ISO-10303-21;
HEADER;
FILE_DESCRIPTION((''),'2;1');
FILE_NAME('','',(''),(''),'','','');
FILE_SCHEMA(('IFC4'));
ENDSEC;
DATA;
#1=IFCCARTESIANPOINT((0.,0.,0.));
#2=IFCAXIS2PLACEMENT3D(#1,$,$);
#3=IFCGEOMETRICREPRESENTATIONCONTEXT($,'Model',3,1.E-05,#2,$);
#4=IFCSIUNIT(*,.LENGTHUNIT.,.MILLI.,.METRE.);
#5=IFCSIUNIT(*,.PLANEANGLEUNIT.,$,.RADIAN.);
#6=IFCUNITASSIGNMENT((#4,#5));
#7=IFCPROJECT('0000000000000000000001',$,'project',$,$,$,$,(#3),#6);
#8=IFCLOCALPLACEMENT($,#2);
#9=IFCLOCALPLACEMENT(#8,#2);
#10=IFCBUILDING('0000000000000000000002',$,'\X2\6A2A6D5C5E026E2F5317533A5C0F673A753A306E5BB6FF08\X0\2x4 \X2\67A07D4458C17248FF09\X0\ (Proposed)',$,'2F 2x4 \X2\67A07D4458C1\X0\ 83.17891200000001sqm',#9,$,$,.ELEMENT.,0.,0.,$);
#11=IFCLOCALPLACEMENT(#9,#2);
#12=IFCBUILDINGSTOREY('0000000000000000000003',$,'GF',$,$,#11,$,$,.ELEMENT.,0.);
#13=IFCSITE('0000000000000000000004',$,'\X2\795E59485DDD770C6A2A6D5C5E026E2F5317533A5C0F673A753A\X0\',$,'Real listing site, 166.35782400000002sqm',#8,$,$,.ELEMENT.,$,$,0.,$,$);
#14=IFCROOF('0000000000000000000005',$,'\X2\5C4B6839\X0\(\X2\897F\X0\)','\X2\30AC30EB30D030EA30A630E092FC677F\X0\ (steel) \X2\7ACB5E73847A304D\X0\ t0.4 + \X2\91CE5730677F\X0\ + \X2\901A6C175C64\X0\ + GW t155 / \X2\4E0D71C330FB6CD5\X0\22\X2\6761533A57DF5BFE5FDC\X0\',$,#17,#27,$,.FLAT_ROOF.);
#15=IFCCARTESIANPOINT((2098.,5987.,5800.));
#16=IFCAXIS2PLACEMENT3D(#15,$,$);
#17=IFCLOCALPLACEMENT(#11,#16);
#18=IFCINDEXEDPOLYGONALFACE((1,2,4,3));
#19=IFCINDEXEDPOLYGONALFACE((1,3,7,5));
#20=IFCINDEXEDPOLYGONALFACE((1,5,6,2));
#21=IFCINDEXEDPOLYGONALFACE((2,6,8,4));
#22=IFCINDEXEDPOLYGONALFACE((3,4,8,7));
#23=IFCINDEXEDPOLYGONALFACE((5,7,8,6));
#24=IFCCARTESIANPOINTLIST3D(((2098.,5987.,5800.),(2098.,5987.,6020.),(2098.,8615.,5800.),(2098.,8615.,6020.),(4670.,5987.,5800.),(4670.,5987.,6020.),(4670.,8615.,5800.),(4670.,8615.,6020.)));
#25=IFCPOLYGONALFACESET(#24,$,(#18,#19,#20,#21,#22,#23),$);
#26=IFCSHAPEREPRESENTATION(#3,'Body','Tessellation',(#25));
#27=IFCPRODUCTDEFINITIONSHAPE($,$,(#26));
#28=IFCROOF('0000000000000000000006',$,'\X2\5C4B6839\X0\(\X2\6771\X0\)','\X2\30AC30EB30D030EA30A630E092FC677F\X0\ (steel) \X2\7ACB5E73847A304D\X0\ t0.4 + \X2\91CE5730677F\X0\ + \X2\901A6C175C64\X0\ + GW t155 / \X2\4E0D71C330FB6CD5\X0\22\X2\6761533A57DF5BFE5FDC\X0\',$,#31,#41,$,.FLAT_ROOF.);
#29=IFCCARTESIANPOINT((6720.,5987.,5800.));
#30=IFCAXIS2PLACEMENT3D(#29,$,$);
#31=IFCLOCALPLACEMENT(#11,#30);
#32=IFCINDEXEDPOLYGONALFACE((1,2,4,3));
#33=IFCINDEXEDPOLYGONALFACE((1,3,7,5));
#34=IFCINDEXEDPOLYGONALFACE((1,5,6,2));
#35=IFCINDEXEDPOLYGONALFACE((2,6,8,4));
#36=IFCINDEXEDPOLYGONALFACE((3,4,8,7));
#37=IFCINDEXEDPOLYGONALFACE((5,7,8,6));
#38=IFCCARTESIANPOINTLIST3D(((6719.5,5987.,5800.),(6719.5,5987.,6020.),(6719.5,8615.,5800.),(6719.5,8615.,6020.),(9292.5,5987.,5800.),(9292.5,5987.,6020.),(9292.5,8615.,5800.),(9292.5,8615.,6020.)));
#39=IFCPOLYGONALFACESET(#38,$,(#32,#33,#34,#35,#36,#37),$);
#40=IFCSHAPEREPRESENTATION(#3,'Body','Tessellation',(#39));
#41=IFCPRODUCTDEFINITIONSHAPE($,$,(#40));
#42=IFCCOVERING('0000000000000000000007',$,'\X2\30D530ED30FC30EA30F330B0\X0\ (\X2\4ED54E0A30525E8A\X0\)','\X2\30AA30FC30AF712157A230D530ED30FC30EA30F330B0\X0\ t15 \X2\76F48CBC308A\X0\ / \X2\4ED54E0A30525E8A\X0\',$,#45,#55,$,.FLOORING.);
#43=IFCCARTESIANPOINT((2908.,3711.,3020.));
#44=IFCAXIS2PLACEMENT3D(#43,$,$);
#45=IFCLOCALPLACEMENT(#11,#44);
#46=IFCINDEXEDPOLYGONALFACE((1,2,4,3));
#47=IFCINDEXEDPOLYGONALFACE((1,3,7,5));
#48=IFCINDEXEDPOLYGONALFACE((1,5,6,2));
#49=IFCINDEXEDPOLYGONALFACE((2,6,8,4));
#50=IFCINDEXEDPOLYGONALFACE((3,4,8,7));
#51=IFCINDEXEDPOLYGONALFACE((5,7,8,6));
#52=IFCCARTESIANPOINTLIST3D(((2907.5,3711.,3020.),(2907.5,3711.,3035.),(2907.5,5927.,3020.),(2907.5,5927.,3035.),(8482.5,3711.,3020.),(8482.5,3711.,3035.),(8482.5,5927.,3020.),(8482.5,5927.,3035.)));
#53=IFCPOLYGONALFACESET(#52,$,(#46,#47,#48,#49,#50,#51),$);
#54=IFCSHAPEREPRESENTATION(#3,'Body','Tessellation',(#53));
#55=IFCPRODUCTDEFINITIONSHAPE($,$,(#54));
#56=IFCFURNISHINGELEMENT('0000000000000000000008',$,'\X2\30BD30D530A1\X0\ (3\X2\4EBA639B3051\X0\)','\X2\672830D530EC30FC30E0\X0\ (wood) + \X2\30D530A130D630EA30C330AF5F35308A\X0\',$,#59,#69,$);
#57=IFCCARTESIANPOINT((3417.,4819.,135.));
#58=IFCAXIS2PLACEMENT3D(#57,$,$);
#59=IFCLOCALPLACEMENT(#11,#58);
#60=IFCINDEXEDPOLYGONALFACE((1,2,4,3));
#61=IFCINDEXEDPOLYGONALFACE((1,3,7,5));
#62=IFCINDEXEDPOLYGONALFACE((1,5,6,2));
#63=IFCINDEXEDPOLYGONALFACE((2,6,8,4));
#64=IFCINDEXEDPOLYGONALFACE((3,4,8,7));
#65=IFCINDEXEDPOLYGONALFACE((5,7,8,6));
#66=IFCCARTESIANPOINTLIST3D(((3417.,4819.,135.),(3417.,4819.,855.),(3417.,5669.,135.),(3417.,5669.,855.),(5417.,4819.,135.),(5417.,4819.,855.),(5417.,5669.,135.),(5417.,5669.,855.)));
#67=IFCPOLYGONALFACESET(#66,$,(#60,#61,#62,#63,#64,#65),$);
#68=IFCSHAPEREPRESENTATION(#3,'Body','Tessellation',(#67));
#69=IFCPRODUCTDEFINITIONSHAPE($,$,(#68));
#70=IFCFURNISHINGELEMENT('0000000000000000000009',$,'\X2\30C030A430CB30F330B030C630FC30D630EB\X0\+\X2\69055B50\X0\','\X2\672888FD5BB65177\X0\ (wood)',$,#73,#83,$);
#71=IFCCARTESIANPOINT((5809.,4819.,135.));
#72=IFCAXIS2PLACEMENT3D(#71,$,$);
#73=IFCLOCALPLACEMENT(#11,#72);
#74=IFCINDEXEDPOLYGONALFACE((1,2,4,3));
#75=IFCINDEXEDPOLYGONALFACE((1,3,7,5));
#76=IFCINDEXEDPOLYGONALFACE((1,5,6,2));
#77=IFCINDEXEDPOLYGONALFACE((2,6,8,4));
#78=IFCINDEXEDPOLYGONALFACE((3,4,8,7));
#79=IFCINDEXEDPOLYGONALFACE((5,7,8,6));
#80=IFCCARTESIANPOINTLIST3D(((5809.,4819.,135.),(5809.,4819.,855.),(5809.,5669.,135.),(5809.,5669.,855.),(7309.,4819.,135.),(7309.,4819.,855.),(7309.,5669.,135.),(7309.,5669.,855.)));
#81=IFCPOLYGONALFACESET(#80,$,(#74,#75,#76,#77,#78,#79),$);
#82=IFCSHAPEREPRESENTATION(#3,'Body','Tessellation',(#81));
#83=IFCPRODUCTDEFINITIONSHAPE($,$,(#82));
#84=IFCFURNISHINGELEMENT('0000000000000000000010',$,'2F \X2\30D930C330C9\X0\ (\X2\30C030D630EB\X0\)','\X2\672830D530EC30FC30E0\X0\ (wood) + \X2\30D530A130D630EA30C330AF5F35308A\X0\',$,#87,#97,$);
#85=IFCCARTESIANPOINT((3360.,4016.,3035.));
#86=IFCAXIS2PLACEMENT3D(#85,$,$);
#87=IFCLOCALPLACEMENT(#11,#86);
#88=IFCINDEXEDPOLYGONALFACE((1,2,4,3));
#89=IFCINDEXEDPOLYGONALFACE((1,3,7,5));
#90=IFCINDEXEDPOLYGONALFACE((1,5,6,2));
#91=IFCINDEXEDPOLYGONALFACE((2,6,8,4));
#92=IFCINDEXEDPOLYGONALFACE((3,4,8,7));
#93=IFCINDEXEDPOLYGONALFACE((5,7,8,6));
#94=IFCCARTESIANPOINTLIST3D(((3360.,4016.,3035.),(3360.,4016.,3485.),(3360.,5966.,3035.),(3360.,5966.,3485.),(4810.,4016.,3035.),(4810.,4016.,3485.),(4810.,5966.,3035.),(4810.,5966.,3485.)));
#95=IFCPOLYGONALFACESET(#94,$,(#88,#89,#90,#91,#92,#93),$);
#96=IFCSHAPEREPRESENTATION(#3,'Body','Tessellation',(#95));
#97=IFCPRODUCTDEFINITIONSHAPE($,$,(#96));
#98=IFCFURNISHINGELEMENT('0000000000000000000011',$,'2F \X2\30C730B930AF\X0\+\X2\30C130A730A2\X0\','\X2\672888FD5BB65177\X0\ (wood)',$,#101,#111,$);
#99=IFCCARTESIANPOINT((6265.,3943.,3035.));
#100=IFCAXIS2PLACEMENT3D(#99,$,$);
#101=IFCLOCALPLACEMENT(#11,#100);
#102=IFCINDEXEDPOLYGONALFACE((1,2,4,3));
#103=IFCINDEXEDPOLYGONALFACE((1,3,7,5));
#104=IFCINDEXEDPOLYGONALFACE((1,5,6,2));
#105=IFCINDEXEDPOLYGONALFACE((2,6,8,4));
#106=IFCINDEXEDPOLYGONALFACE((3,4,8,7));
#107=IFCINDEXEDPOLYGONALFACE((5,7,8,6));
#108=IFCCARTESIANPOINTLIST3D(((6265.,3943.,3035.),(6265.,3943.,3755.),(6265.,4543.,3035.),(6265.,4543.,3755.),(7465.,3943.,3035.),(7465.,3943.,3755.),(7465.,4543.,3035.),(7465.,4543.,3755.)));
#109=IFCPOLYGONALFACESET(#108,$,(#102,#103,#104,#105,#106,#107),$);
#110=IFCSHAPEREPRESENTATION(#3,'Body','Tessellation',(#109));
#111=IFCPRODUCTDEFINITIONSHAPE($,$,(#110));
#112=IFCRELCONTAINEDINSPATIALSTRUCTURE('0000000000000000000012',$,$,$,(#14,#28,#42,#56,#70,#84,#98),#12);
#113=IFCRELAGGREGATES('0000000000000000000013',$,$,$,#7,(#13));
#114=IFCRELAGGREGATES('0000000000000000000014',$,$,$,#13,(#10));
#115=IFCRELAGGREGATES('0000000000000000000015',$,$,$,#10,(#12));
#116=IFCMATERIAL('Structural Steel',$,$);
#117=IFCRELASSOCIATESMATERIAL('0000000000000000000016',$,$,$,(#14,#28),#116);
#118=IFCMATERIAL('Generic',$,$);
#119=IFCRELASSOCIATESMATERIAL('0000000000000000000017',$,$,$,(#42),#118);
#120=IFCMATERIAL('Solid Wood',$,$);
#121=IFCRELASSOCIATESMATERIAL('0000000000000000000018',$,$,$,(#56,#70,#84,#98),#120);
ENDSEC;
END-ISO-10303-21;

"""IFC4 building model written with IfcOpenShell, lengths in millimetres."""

from ifc_helpers import new_model, si_unit, frame, frame_2d, origin, place, context, project, spatial, rectangle, extrude, material, element, save


model = new_model("IFC4")

# Units and contexts
model_context = context("Model", 3, precision=1e-05, world=origin())
ifc_project = project(units=[si_unit("LENGTHUNIT", "METRE", prefix="MILLI"), si_unit("PLANEANGLEUNIT", "RADIAN")], contexts=[model_context])

# Site, building, storey
site_placement = place(None, origin())
site = spatial("IfcSite", under=ifc_project, at=site_placement, Name="神奈川県横浜市港北区小机町", ObjectType="Real listing site, 166.35782400000002sqm", CompositionType="ELEMENT", RefElevation=0.0)
building_placement = place(site_placement, origin())
building = spatial("IfcBuilding", under=site, at=building_placement, Name="横浜市港北区小机町の家（2x4 枠組壁版） (Proposed)", ObjectType="2F 2x4 枠組壁 83.17891200000001sqm", CompositionType="ELEMENT", ElevationOfRefHeight=0.0, ElevationOfTerrain=0.0)
storey_placement = place(building_placement, origin())
storey = spatial("IfcBuildingStorey", under=building, at=storey_placement, Name="GF", CompositionType="ELEMENT", Elevation=0.0)

# Shared definitions
ifc_material_1 = material(Name="Solid Wood")

# Roofs
ifc_material_2 = material(Name="Structural Steel")
roof_1_placement = place(storey_placement, frame((2098.0, 5987.0, 5800.0)))
element("IfcRoof", 1, at=roof_1_placement, inside=storey, material=ifc_material_2, Name="屋根(西)", Description="ガルバリウム鋼板 (steel) 立平葺き t0.4 + 野地板 + 通気層 + GW t155 / 不燃・法22条区域対応", PredefinedType="FLAT_ROOF", context=model_context, shape_type="SweptSolid", body=[
    extrude(rectangle(XDim=2572.0, YDim=2628.0, at=frame_2d((1286.0, 1314.0))), frame((2098.0, 5987.0, 5800.0)), (0.0, 0.0, 1.0), 220.0),
])
roof_2_placement = place(storey_placement, frame((6720.0, 5987.0, 5800.0)))
element("IfcRoof", 2, at=roof_2_placement, inside=storey, material=ifc_material_2, Name="屋根(東)", Description="ガルバリウム鋼板 (steel) 立平葺き t0.4 + 野地板 + 通気層 + GW t155 / 不燃・法22条区域対応", PredefinedType="FLAT_ROOF", context=model_context, shape_type="SweptSolid", body=[
    extrude(rectangle(XDim=2573.0, YDim=2628.0, at=frame_2d((1286.0, 1314.0))), frame((6720.0, 5987.0, 5800.0)), (0.0, 0.0, 1.0), 220.0),
])

# Covering
ifc_material_3 = material(Name="Generic")
covering_placement = place(storey_placement, frame((2908.0, 3711.0, 3020.0)))
element("IfcCovering", 3, at=covering_placement, inside=storey, material=ifc_material_3, Name="フローリング (仕上げ床)", Description="オーク無垢フローリング t15 直貼り / 仕上げ床", PredefinedType="FLOORING", context=model_context, shape_type="SweptSolid", body=[
    extrude(rectangle(XDim=5575.0, YDim=2216.0, at=frame_2d((2787.0, 1108.0))), frame((2908.0, 3711.0, 3020.0)), (0.0, 0.0, 1.0), 15.0),
])

# Furnishing elements
furnishing_1_placement = place(storey_placement, frame((3417.0, 4819.0, 135.0)))
element("IfcFurnishingElement", 4, at=furnishing_1_placement, inside=storey, material=ifc_material_1, Name="ソファ (3人掛け)", Description="木フレーム (wood) + ファブリック張り", context=model_context, shape_type="SweptSolid", body=[
    extrude(rectangle(XDim=2000.0, YDim=850.0, at=frame_2d((1000.0, 425.0))), frame((3417.0, 4819.0, 135.0)), (0.0, 0.0, 1.0), 720.0),
])
furnishing_2_placement = place(storey_placement, frame((5809.0, 4819.0, 135.0)))
element("IfcFurnishingElement", 5, at=furnishing_2_placement, inside=storey, material=ifc_material_1, Name="ダイニングテーブル+椅子", Description="木製家具 (wood)", context=model_context, shape_type="SweptSolid", body=[
    extrude(rectangle(XDim=1500.0, YDim=850.0, at=frame_2d((750.0, 425.0))), frame((5809.0, 4819.0, 135.0)), (0.0, 0.0, 1.0), 720.0),
])
furnishing_3_placement = place(storey_placement, frame((3360.0, 4016.0, 3035.0)))
element("IfcFurnishingElement", 6, at=furnishing_3_placement, inside=storey, material=ifc_material_1, Name="2F ベッド (ダブル)", Description="木フレーム (wood) + ファブリック張り", context=model_context, shape_type="SweptSolid", body=[
    extrude(rectangle(XDim=1450.0, YDim=1950.0, at=frame_2d((725.0, 975.0))), frame((3360.0, 4016.0, 3035.0)), (0.0, 0.0, 1.0), 450.0),
])
furnishing_4_placement = place(storey_placement, frame((6265.0, 3943.0, 3035.0)))
element("IfcFurnishingElement", 7, at=furnishing_4_placement, inside=storey, material=ifc_material_1, Name="2F デスク+チェア", Description="木製家具 (wood)", context=model_context, shape_type="SweptSolid", body=[
    extrude(rectangle(XDim=1200.0, YDim=600.0, at=frame_2d((600.0, 300.0))), frame((6265.0, 3943.0, 3035.0)), (0.0, 0.0, 1.0), 720.0),
])

save(model, "model.ifc")
